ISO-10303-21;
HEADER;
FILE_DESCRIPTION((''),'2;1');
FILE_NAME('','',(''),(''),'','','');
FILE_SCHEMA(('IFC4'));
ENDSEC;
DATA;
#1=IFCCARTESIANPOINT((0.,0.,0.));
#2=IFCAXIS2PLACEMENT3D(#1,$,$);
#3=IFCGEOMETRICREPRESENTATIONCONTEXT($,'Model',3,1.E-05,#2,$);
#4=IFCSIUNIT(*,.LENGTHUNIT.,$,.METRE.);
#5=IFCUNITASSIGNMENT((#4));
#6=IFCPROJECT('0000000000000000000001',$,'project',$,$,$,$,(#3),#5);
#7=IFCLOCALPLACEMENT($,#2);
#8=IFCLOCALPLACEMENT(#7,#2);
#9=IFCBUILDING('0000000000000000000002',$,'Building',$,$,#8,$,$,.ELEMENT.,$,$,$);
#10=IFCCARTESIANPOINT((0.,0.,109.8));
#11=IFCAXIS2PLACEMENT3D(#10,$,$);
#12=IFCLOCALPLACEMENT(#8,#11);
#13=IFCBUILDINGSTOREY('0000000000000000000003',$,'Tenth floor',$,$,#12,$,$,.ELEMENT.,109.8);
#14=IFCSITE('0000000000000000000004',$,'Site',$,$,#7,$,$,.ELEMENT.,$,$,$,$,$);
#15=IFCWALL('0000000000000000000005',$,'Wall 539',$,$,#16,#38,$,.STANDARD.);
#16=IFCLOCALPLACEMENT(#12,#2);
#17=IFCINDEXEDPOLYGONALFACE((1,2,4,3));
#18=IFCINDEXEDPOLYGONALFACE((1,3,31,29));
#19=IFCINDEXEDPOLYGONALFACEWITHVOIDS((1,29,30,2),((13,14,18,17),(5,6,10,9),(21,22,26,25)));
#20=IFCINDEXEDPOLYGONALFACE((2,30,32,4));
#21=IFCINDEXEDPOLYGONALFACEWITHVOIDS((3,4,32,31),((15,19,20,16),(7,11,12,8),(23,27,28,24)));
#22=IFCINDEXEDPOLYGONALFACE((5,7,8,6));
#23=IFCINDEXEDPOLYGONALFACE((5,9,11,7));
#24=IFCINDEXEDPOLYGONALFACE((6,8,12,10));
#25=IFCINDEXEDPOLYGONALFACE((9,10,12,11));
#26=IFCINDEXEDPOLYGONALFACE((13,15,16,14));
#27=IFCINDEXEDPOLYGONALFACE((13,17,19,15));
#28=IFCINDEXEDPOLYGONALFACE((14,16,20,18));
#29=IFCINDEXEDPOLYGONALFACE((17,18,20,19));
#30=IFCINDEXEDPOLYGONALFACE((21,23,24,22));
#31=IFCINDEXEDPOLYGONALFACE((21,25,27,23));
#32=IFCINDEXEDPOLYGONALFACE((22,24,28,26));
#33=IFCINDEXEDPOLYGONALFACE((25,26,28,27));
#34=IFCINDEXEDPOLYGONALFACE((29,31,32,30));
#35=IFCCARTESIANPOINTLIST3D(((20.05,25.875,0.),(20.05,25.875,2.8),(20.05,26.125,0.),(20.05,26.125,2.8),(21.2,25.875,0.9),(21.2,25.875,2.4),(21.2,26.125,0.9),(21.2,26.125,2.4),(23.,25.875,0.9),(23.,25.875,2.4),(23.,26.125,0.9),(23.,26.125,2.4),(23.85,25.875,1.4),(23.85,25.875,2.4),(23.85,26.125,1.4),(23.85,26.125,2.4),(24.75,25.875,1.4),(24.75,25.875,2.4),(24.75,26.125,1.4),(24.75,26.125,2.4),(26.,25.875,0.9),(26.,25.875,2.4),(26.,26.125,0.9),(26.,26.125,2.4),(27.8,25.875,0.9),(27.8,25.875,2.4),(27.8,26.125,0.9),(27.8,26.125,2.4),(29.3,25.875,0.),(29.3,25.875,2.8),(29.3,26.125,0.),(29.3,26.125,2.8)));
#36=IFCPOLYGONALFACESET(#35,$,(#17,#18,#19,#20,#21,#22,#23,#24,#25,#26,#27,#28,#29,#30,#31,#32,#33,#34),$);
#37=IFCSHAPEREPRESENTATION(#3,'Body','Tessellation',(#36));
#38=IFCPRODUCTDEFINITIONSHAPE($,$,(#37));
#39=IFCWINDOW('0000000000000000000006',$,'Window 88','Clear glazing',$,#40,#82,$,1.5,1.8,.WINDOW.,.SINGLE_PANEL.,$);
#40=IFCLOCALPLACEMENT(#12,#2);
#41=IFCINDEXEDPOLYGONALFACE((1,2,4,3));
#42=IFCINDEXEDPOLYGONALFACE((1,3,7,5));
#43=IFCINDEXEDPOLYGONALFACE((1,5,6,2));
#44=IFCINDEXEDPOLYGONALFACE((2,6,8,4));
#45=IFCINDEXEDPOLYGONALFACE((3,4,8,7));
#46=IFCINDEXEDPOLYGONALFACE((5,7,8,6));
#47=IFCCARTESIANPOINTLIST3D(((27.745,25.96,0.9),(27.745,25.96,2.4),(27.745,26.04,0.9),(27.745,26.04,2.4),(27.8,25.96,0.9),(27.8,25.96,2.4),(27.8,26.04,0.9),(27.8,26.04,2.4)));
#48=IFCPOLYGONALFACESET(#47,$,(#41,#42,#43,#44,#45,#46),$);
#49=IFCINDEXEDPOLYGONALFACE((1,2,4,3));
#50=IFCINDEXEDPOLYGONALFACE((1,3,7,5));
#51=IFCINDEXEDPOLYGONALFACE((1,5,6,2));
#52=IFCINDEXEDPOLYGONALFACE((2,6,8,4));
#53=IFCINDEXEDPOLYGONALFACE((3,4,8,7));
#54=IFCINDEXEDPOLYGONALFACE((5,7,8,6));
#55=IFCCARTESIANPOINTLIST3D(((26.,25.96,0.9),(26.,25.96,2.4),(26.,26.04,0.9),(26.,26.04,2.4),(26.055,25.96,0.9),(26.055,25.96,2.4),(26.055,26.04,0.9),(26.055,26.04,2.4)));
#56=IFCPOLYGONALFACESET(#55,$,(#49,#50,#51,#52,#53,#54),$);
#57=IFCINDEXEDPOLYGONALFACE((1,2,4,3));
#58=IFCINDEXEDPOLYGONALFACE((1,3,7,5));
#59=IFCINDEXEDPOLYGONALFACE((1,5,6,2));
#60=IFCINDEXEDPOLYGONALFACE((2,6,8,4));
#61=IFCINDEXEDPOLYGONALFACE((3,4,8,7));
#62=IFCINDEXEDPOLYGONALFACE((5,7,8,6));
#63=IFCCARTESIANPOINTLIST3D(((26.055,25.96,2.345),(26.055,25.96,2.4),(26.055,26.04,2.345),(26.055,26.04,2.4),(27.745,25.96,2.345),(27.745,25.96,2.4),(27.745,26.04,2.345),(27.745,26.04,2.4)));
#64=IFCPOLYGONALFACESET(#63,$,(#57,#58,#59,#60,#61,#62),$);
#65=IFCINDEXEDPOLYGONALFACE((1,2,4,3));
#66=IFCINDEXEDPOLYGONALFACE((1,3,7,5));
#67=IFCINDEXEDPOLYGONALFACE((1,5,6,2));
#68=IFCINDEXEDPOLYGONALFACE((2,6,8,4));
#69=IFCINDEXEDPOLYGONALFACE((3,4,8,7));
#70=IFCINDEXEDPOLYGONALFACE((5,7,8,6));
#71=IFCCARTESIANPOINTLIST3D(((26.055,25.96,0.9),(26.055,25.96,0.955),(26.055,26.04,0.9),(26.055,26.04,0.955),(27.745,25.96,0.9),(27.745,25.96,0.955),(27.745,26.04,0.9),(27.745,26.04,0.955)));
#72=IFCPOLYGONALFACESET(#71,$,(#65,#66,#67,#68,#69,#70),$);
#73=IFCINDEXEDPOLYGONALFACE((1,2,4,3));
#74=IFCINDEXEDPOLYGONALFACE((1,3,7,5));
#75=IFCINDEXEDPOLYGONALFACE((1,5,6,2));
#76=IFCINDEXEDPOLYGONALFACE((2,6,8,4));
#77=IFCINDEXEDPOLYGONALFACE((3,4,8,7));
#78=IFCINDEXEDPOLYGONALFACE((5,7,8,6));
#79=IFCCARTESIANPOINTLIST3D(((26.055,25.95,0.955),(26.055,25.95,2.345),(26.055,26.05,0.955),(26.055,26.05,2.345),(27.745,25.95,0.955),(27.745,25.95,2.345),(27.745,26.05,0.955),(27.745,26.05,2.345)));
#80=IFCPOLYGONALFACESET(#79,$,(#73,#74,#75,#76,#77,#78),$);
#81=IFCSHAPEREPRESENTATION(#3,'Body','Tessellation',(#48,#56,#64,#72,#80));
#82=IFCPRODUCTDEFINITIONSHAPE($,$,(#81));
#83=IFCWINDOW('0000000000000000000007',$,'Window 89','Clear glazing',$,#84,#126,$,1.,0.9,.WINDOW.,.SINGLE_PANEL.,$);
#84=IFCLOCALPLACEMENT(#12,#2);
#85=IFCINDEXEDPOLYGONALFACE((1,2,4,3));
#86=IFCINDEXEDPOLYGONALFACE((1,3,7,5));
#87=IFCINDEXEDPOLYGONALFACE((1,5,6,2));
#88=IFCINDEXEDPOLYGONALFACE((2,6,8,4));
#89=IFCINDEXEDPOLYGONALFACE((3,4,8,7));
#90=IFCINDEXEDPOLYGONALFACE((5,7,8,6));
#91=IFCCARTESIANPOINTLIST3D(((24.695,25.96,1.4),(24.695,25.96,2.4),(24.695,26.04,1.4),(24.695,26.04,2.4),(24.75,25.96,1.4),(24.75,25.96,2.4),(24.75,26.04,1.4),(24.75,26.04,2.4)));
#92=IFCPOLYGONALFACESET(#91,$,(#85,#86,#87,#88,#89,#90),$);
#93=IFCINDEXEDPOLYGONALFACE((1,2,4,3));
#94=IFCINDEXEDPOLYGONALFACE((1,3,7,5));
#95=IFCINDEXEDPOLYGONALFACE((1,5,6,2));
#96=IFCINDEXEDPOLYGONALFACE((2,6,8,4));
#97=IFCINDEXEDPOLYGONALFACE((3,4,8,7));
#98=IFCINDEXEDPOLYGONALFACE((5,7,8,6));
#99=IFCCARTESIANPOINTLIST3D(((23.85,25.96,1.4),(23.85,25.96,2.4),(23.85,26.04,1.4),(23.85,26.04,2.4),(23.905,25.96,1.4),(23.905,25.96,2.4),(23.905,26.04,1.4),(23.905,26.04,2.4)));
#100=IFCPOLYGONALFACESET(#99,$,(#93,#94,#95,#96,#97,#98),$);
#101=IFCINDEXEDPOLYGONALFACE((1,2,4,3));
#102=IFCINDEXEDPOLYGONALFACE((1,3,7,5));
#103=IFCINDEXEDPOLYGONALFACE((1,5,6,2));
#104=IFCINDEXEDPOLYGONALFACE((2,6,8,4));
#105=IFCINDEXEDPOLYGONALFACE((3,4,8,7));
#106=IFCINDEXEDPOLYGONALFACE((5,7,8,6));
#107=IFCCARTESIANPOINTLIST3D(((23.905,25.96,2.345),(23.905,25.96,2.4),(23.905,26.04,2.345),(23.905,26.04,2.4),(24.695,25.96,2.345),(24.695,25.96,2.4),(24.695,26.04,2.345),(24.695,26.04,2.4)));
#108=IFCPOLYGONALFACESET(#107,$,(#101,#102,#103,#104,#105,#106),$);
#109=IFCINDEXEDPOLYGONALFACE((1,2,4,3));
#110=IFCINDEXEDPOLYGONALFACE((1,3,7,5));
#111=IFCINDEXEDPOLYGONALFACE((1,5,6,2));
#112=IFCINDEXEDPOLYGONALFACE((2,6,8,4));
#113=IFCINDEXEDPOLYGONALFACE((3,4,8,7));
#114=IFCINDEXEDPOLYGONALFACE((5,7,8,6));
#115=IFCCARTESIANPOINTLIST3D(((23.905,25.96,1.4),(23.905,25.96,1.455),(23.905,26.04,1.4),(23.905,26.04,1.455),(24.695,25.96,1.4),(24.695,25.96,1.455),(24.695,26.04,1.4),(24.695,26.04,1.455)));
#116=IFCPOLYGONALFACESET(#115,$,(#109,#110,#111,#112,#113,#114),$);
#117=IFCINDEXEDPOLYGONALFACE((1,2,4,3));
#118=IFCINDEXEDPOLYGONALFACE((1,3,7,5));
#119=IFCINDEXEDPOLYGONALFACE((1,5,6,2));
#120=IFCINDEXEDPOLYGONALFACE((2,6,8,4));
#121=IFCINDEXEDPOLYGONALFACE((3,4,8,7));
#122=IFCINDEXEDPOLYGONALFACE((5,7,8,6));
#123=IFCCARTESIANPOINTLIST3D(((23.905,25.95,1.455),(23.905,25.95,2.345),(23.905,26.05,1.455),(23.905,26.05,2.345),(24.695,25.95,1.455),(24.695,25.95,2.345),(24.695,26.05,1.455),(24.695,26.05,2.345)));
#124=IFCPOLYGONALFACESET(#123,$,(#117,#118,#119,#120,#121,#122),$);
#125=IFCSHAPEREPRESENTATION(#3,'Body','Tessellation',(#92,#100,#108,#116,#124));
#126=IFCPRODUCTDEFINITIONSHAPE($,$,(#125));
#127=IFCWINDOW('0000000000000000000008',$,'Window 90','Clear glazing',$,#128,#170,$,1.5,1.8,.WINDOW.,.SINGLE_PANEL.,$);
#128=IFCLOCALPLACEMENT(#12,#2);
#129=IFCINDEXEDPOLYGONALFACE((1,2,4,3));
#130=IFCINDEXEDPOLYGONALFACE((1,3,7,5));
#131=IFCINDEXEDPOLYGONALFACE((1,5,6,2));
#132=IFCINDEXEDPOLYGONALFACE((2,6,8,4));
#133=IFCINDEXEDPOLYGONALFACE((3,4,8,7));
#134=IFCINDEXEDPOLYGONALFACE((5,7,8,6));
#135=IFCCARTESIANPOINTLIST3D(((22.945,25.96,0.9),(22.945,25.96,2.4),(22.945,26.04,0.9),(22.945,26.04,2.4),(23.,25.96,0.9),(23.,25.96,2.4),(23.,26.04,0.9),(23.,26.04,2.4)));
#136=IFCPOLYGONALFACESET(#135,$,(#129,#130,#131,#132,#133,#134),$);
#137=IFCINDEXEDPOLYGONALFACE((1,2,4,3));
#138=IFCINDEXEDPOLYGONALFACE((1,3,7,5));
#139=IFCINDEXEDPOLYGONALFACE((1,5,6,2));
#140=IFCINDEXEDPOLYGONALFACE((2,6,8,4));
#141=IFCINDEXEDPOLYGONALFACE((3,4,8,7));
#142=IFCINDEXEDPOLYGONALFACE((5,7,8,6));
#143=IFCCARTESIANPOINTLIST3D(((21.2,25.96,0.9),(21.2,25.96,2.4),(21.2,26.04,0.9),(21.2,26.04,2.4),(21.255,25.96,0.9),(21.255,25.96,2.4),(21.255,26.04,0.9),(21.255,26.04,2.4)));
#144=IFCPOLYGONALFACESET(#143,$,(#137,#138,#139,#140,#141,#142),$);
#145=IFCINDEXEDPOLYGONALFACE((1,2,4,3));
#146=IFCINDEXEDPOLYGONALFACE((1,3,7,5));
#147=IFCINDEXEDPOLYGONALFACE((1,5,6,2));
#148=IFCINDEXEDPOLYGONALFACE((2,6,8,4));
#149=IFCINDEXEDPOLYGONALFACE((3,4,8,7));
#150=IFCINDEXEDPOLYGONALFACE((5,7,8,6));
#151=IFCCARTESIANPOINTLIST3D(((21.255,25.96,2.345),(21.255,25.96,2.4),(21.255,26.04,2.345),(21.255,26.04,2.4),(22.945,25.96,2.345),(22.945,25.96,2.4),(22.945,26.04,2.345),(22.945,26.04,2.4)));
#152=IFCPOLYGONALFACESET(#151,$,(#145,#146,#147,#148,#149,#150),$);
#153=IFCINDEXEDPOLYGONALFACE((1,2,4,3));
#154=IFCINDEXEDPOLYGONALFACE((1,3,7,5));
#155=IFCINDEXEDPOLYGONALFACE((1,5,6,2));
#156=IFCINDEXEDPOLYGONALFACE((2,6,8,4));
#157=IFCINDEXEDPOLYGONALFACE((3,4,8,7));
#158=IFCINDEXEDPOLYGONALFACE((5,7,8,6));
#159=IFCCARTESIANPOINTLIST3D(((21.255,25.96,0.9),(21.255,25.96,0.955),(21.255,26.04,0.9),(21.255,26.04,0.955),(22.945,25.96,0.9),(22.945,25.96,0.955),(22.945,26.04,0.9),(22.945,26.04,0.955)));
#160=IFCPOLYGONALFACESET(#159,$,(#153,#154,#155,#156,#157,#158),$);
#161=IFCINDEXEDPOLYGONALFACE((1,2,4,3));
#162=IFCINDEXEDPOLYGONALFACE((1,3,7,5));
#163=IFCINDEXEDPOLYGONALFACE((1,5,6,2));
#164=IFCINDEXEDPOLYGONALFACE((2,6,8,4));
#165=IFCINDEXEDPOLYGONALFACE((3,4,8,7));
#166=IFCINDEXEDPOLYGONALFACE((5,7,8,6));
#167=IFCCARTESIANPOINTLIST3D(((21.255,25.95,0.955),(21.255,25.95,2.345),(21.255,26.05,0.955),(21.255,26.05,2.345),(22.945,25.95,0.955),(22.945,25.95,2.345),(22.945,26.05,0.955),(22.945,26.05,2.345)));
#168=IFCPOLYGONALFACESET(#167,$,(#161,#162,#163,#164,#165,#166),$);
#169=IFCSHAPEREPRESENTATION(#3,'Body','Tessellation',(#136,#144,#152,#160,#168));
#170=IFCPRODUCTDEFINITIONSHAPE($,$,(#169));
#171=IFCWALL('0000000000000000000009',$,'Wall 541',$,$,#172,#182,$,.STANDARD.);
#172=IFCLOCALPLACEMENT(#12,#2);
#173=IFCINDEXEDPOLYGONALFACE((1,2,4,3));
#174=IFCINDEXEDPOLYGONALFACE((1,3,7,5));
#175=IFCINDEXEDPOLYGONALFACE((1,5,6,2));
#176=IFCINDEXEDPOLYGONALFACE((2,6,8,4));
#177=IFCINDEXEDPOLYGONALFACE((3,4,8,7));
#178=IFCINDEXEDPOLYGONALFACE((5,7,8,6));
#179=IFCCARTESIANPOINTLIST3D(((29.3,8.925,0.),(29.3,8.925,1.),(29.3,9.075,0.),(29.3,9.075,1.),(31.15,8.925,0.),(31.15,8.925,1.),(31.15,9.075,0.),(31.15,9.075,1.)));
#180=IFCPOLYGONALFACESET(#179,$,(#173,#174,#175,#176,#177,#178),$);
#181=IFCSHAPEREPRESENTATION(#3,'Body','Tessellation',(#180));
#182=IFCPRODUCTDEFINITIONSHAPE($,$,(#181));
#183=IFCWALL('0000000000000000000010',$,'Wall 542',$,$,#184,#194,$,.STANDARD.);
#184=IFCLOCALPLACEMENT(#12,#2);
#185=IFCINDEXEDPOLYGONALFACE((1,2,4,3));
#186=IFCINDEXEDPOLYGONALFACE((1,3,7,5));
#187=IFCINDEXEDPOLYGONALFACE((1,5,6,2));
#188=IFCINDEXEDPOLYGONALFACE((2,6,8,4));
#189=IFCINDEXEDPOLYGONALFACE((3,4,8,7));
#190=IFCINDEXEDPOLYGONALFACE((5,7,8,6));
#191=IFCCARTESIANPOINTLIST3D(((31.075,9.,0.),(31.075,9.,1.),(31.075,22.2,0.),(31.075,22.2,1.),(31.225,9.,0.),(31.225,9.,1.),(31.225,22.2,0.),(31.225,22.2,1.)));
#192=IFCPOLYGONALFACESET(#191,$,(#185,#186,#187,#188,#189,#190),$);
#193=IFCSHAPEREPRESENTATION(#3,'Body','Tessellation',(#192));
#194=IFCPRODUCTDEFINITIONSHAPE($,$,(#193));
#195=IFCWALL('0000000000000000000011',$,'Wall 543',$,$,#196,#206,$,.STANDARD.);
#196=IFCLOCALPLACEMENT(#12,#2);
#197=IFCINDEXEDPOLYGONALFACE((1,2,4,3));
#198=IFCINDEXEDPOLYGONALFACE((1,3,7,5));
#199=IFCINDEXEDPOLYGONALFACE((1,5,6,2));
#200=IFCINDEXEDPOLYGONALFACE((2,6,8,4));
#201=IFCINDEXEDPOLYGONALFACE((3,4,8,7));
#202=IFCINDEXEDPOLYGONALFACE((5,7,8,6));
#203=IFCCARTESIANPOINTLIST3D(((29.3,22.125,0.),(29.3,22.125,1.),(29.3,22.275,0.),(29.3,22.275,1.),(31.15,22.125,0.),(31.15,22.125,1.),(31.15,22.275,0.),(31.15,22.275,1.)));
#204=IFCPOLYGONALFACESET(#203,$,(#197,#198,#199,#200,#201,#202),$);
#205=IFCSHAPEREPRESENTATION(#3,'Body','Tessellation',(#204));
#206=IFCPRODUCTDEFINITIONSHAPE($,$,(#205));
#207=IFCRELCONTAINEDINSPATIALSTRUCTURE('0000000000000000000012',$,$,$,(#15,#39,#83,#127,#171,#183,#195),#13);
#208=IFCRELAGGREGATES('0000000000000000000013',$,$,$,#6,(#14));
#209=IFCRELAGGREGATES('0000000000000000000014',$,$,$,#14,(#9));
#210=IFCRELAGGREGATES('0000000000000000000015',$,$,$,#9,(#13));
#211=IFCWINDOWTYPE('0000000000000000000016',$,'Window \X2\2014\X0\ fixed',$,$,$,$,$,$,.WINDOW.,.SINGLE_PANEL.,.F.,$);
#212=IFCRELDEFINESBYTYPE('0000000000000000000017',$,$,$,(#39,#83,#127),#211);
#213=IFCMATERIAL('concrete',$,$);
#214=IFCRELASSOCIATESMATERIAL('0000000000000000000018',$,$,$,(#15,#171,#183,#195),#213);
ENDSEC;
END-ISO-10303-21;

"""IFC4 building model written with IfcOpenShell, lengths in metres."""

from ifc_helpers import new_model, si_unit, frame, frame_2d, origin, place, context, project, spatial, rectangle, extrude, material, type_object, element, fill, save


model = new_model("IFC4")

# Units and contexts
model_context = context("Model", 3, precision=1e-05, world=origin())
ifc_project = project(units=[si_unit("LENGTHUNIT", "METRE")], contexts=[model_context])

# Site, building, storey
site_placement = place(None, origin())
site = spatial("IfcSite", under=ifc_project, at=site_placement, Name="Site", CompositionType="ELEMENT")
building_placement = place(site_placement, origin())
building = spatial("IfcBuilding", under=site, at=building_placement, Name="Building", CompositionType="ELEMENT")
storey_placement = place(building_placement, frame((0.0, 0.0, 109.8)))
storey = spatial("IfcBuildingStorey", under=building, at=storey_placement, Name="Tenth floor", CompositionType="ELEMENT", Elevation=109.8)

# Shared definitions
ifc_material = material(Name="concrete")

# Shared definitions
window_type = type_object("IfcWindowType", Name="Window — fixed", ParameterTakesPrecedence=False, PartitioningType="SINGLE_PANEL", PredefinedType="WINDOW")

# Wall, openings, windows
wall_1_placement = place(storey_placement, frame((29.3, 26.0, 0.0), z_axis=(0.0, 0.0, 1.0), x_axis=(-1.0, 0.0, 0.0)))
wall_1 = element("IfcWall", 1, at=wall_1_placement, inside=storey, material=ifc_material, Name="Wall 539", PredefinedType="STANDARD", context=model_context, shape_type="SweptSolid", body=[
    extrude(rectangle(XDim=9.25, YDim=0.25, at=frame_2d((4.625, 0.0))), origin(), (0.0, 0.0, 1.0), 2.8),
])
opening_1_placement = place(storey_placement, frame((27.8, 26.0, 0.9), z_axis=(0.0, 0.0, 1.0), x_axis=(-1.0, 0.0, 0.0)))
opening_1 = element("IfcOpeningElement", 2, at=opening_1_placement, cuts=wall_1, PredefinedType="OPENING", context=model_context, shape_type="SweptSolid", body=[
    extrude(rectangle(XDim=1.8, YDim=0.31, at=frame_2d((0.9, 0.0))), origin(), (0.0, 0.0, 1.0), 1.5),
])
opening_2_placement = place(storey_placement, frame((24.75, 26.0, 1.4), z_axis=(0.0, 0.0, 1.0), x_axis=(-1.0, 0.0, 0.0)))
opening_2 = element("IfcOpeningElement", 3, at=opening_2_placement, cuts=wall_1, PredefinedType="OPENING", context=model_context, shape_type="SweptSolid", body=[
    extrude(rectangle(XDim=0.9, YDim=0.31, at=frame_2d((0.45, 0.0))), origin(), (0.0, 0.0, 1.0), 1.0),
])
opening_3_placement = place(storey_placement, frame((23.0, 26.0, 0.9), z_axis=(0.0, 0.0, 1.0), x_axis=(-1.0, 0.0, 0.0)))
opening_3 = element("IfcOpeningElement", 4, at=opening_3_placement, cuts=wall_1, PredefinedType="OPENING", context=model_context, shape_type="SweptSolid", body=[
    extrude(rectangle(XDim=1.8, YDim=0.31, at=frame_2d((0.9, 0.0))), origin(), (0.0, 0.0, 1.0), 1.5),
])
window_1_placement = place(storey_placement, frame((27.8, 26.0, 0.9), z_axis=(0.0, 0.0, 1.0), x_axis=(-1.0, 0.0, 0.0)))
window_1 = element("IfcWindow", 5, at=window_1_placement, inside=storey, type_object=window_type, Name="Window 88", Description="Clear glazing", OverallHeight=1.5, OverallWidth=1.8, PartitioningType="SINGLE_PANEL", PredefinedType="WINDOW", context=model_context, shape_type="SweptSolid", body=[
    extrude(rectangle(XDim=0.055, YDim=0.08, at=frame_2d((0.0275, 0.0))), origin(), (0.0, 0.0, 1.0), 1.5),
    extrude(rectangle(XDim=0.055, YDim=0.08, at=frame_2d((1.7725, 0.0))), origin(), (0.0, 0.0, 1.0), 1.5),
    extrude(rectangle(XDim=1.69, YDim=0.08, at=frame_2d((0.9, 0.0))), frame((0.0, 0.0, 1.445)), (0.0, 0.0, 1.0), 0.055),
    extrude(rectangle(XDim=1.69, YDim=0.08, at=frame_2d((0.9, 0.0))), origin(), (0.0, 0.0, 1.0), 0.055),
    extrude(rectangle(XDim=1.69, YDim=0.1, at=frame_2d((0.9, 0.0))), frame((0.0, 0.0, 0.055)), (0.0, 0.0, 1.0), 1.39),
])
fill(opening_1, window_1)
window_2_placement = place(storey_placement, frame((24.75, 26.0, 1.4), z_axis=(0.0, 0.0, 1.0), x_axis=(-1.0, 0.0, 0.0)))
window_2 = element("IfcWindow", 6, at=window_2_placement, inside=storey, type_object=window_type, Name="Window 89", Description="Clear glazing", OverallHeight=1.0, OverallWidth=0.9, PartitioningType="SINGLE_PANEL", PredefinedType="WINDOW", context=model_context, shape_type="SweptSolid", body=[
    extrude(rectangle(XDim=0.055, YDim=0.08, at=frame_2d((0.0275, 0.0))), origin(), (0.0, 0.0, 1.0), 1.0),
    extrude(rectangle(XDim=0.055, YDim=0.08, at=frame_2d((0.8725, 0.0))), origin(), (0.0, 0.0, 1.0), 1.0),
    extrude(rectangle(XDim=0.79, YDim=0.08, at=frame_2d((0.45, 0.0))), frame((0.0, 0.0, 0.945)), (0.0, 0.0, 1.0), 0.055),
    extrude(rectangle(XDim=0.79, YDim=0.08, at=frame_2d((0.45, 0.0))), origin(), (0.0, 0.0, 1.0), 0.055),
    extrude(rectangle(XDim=0.79, YDim=0.1, at=frame_2d((0.45, 0.0))), frame((0.0, 0.0, 0.055)), (0.0, 0.0, 1.0), 0.89),
])
fill(opening_2, window_2)
window_3_placement = place(storey_placement, frame((23.0, 26.0, 0.9), z_axis=(0.0, 0.0, 1.0), x_axis=(-1.0, 0.0, 0.0)))
window_3 = element("IfcWindow", 7, at=window_3_placement, inside=storey, type_object=window_type, Name="Window 90", Description="Clear glazing", OverallHeight=1.5, OverallWidth=1.8, PartitioningType="SINGLE_PANEL", PredefinedType="WINDOW", context=model_context, shape_type="SweptSolid", body=[
    extrude(rectangle(XDim=0.055, YDim=0.08, at=frame_2d((0.0275, 0.0))), origin(), (0.0, 0.0, 1.0), 1.5),
    extrude(rectangle(XDim=0.055, YDim=0.08, at=frame_2d((1.7725, 0.0))), origin(), (0.0, 0.0, 1.0), 1.5),
    extrude(rectangle(XDim=1.69, YDim=0.08, at=frame_2d((0.9, 0.0))), frame((0.0, 0.0, 1.445)), (0.0, 0.0, 1.0), 0.055),
    extrude(rectangle(XDim=1.69, YDim=0.08, at=frame_2d((0.9, 0.0))), origin(), (0.0, 0.0, 1.0), 0.055),
    extrude(rectangle(XDim=1.69, YDim=0.1, at=frame_2d((0.9, 0.0))), frame((0.0, 0.0, 0.055)), (0.0, 0.0, 1.0), 1.39),
])
fill(opening_3, window_3)

# Walls
wall_2_placement = place(storey_placement, frame((29.3, 9.0, 0.0), z_axis=(0.0, 0.0, 1.0), x_axis=(1.0, 0.0, 0.0)))
element("IfcWall", 8, at=wall_2_placement, inside=storey, material=ifc_material, Name="Wall 541", PredefinedType="STANDARD", context=model_context, shape_type="SweptSolid", body=[
    extrude(rectangle(XDim=1.85, YDim=0.15, at=frame_2d((0.925, 0.0))), origin(), (0.0, 0.0, 1.0), 1.0),
])
wall_3_placement = place(storey_placement, frame((31.15, 9.0, 0.0), z_axis=(0.0, 0.0, 1.0), x_axis=(0.0, 1.0, 0.0)))
element("IfcWall", 9, at=wall_3_placement, inside=storey, material=ifc_material, Name="Wall 542", PredefinedType="STANDARD", context=model_context, shape_type="SweptSolid", body=[
    extrude(rectangle(XDim=13.2, YDim=0.15, at=frame_2d((6.6, 0.0))), origin(), (0.0, 0.0, 1.0), 1.0),
])
wall_4_placement = place(storey_placement, frame((31.15, 22.2, 0.0), z_axis=(0.0, 0.0, 1.0), x_axis=(-1.0, 0.0, 0.0)))
element("IfcWall", 10, at=wall_4_placement, inside=storey, material=ifc_material, Name="Wall 543", PredefinedType="STANDARD", context=model_context, shape_type="SweptSolid", body=[
    extrude(rectangle(XDim=1.85, YDim=0.15, at=frame_2d((0.925, 0.0))), origin(), (0.0, 0.0, 1.0), 1.0),
])

save(model, "model.ifc")
